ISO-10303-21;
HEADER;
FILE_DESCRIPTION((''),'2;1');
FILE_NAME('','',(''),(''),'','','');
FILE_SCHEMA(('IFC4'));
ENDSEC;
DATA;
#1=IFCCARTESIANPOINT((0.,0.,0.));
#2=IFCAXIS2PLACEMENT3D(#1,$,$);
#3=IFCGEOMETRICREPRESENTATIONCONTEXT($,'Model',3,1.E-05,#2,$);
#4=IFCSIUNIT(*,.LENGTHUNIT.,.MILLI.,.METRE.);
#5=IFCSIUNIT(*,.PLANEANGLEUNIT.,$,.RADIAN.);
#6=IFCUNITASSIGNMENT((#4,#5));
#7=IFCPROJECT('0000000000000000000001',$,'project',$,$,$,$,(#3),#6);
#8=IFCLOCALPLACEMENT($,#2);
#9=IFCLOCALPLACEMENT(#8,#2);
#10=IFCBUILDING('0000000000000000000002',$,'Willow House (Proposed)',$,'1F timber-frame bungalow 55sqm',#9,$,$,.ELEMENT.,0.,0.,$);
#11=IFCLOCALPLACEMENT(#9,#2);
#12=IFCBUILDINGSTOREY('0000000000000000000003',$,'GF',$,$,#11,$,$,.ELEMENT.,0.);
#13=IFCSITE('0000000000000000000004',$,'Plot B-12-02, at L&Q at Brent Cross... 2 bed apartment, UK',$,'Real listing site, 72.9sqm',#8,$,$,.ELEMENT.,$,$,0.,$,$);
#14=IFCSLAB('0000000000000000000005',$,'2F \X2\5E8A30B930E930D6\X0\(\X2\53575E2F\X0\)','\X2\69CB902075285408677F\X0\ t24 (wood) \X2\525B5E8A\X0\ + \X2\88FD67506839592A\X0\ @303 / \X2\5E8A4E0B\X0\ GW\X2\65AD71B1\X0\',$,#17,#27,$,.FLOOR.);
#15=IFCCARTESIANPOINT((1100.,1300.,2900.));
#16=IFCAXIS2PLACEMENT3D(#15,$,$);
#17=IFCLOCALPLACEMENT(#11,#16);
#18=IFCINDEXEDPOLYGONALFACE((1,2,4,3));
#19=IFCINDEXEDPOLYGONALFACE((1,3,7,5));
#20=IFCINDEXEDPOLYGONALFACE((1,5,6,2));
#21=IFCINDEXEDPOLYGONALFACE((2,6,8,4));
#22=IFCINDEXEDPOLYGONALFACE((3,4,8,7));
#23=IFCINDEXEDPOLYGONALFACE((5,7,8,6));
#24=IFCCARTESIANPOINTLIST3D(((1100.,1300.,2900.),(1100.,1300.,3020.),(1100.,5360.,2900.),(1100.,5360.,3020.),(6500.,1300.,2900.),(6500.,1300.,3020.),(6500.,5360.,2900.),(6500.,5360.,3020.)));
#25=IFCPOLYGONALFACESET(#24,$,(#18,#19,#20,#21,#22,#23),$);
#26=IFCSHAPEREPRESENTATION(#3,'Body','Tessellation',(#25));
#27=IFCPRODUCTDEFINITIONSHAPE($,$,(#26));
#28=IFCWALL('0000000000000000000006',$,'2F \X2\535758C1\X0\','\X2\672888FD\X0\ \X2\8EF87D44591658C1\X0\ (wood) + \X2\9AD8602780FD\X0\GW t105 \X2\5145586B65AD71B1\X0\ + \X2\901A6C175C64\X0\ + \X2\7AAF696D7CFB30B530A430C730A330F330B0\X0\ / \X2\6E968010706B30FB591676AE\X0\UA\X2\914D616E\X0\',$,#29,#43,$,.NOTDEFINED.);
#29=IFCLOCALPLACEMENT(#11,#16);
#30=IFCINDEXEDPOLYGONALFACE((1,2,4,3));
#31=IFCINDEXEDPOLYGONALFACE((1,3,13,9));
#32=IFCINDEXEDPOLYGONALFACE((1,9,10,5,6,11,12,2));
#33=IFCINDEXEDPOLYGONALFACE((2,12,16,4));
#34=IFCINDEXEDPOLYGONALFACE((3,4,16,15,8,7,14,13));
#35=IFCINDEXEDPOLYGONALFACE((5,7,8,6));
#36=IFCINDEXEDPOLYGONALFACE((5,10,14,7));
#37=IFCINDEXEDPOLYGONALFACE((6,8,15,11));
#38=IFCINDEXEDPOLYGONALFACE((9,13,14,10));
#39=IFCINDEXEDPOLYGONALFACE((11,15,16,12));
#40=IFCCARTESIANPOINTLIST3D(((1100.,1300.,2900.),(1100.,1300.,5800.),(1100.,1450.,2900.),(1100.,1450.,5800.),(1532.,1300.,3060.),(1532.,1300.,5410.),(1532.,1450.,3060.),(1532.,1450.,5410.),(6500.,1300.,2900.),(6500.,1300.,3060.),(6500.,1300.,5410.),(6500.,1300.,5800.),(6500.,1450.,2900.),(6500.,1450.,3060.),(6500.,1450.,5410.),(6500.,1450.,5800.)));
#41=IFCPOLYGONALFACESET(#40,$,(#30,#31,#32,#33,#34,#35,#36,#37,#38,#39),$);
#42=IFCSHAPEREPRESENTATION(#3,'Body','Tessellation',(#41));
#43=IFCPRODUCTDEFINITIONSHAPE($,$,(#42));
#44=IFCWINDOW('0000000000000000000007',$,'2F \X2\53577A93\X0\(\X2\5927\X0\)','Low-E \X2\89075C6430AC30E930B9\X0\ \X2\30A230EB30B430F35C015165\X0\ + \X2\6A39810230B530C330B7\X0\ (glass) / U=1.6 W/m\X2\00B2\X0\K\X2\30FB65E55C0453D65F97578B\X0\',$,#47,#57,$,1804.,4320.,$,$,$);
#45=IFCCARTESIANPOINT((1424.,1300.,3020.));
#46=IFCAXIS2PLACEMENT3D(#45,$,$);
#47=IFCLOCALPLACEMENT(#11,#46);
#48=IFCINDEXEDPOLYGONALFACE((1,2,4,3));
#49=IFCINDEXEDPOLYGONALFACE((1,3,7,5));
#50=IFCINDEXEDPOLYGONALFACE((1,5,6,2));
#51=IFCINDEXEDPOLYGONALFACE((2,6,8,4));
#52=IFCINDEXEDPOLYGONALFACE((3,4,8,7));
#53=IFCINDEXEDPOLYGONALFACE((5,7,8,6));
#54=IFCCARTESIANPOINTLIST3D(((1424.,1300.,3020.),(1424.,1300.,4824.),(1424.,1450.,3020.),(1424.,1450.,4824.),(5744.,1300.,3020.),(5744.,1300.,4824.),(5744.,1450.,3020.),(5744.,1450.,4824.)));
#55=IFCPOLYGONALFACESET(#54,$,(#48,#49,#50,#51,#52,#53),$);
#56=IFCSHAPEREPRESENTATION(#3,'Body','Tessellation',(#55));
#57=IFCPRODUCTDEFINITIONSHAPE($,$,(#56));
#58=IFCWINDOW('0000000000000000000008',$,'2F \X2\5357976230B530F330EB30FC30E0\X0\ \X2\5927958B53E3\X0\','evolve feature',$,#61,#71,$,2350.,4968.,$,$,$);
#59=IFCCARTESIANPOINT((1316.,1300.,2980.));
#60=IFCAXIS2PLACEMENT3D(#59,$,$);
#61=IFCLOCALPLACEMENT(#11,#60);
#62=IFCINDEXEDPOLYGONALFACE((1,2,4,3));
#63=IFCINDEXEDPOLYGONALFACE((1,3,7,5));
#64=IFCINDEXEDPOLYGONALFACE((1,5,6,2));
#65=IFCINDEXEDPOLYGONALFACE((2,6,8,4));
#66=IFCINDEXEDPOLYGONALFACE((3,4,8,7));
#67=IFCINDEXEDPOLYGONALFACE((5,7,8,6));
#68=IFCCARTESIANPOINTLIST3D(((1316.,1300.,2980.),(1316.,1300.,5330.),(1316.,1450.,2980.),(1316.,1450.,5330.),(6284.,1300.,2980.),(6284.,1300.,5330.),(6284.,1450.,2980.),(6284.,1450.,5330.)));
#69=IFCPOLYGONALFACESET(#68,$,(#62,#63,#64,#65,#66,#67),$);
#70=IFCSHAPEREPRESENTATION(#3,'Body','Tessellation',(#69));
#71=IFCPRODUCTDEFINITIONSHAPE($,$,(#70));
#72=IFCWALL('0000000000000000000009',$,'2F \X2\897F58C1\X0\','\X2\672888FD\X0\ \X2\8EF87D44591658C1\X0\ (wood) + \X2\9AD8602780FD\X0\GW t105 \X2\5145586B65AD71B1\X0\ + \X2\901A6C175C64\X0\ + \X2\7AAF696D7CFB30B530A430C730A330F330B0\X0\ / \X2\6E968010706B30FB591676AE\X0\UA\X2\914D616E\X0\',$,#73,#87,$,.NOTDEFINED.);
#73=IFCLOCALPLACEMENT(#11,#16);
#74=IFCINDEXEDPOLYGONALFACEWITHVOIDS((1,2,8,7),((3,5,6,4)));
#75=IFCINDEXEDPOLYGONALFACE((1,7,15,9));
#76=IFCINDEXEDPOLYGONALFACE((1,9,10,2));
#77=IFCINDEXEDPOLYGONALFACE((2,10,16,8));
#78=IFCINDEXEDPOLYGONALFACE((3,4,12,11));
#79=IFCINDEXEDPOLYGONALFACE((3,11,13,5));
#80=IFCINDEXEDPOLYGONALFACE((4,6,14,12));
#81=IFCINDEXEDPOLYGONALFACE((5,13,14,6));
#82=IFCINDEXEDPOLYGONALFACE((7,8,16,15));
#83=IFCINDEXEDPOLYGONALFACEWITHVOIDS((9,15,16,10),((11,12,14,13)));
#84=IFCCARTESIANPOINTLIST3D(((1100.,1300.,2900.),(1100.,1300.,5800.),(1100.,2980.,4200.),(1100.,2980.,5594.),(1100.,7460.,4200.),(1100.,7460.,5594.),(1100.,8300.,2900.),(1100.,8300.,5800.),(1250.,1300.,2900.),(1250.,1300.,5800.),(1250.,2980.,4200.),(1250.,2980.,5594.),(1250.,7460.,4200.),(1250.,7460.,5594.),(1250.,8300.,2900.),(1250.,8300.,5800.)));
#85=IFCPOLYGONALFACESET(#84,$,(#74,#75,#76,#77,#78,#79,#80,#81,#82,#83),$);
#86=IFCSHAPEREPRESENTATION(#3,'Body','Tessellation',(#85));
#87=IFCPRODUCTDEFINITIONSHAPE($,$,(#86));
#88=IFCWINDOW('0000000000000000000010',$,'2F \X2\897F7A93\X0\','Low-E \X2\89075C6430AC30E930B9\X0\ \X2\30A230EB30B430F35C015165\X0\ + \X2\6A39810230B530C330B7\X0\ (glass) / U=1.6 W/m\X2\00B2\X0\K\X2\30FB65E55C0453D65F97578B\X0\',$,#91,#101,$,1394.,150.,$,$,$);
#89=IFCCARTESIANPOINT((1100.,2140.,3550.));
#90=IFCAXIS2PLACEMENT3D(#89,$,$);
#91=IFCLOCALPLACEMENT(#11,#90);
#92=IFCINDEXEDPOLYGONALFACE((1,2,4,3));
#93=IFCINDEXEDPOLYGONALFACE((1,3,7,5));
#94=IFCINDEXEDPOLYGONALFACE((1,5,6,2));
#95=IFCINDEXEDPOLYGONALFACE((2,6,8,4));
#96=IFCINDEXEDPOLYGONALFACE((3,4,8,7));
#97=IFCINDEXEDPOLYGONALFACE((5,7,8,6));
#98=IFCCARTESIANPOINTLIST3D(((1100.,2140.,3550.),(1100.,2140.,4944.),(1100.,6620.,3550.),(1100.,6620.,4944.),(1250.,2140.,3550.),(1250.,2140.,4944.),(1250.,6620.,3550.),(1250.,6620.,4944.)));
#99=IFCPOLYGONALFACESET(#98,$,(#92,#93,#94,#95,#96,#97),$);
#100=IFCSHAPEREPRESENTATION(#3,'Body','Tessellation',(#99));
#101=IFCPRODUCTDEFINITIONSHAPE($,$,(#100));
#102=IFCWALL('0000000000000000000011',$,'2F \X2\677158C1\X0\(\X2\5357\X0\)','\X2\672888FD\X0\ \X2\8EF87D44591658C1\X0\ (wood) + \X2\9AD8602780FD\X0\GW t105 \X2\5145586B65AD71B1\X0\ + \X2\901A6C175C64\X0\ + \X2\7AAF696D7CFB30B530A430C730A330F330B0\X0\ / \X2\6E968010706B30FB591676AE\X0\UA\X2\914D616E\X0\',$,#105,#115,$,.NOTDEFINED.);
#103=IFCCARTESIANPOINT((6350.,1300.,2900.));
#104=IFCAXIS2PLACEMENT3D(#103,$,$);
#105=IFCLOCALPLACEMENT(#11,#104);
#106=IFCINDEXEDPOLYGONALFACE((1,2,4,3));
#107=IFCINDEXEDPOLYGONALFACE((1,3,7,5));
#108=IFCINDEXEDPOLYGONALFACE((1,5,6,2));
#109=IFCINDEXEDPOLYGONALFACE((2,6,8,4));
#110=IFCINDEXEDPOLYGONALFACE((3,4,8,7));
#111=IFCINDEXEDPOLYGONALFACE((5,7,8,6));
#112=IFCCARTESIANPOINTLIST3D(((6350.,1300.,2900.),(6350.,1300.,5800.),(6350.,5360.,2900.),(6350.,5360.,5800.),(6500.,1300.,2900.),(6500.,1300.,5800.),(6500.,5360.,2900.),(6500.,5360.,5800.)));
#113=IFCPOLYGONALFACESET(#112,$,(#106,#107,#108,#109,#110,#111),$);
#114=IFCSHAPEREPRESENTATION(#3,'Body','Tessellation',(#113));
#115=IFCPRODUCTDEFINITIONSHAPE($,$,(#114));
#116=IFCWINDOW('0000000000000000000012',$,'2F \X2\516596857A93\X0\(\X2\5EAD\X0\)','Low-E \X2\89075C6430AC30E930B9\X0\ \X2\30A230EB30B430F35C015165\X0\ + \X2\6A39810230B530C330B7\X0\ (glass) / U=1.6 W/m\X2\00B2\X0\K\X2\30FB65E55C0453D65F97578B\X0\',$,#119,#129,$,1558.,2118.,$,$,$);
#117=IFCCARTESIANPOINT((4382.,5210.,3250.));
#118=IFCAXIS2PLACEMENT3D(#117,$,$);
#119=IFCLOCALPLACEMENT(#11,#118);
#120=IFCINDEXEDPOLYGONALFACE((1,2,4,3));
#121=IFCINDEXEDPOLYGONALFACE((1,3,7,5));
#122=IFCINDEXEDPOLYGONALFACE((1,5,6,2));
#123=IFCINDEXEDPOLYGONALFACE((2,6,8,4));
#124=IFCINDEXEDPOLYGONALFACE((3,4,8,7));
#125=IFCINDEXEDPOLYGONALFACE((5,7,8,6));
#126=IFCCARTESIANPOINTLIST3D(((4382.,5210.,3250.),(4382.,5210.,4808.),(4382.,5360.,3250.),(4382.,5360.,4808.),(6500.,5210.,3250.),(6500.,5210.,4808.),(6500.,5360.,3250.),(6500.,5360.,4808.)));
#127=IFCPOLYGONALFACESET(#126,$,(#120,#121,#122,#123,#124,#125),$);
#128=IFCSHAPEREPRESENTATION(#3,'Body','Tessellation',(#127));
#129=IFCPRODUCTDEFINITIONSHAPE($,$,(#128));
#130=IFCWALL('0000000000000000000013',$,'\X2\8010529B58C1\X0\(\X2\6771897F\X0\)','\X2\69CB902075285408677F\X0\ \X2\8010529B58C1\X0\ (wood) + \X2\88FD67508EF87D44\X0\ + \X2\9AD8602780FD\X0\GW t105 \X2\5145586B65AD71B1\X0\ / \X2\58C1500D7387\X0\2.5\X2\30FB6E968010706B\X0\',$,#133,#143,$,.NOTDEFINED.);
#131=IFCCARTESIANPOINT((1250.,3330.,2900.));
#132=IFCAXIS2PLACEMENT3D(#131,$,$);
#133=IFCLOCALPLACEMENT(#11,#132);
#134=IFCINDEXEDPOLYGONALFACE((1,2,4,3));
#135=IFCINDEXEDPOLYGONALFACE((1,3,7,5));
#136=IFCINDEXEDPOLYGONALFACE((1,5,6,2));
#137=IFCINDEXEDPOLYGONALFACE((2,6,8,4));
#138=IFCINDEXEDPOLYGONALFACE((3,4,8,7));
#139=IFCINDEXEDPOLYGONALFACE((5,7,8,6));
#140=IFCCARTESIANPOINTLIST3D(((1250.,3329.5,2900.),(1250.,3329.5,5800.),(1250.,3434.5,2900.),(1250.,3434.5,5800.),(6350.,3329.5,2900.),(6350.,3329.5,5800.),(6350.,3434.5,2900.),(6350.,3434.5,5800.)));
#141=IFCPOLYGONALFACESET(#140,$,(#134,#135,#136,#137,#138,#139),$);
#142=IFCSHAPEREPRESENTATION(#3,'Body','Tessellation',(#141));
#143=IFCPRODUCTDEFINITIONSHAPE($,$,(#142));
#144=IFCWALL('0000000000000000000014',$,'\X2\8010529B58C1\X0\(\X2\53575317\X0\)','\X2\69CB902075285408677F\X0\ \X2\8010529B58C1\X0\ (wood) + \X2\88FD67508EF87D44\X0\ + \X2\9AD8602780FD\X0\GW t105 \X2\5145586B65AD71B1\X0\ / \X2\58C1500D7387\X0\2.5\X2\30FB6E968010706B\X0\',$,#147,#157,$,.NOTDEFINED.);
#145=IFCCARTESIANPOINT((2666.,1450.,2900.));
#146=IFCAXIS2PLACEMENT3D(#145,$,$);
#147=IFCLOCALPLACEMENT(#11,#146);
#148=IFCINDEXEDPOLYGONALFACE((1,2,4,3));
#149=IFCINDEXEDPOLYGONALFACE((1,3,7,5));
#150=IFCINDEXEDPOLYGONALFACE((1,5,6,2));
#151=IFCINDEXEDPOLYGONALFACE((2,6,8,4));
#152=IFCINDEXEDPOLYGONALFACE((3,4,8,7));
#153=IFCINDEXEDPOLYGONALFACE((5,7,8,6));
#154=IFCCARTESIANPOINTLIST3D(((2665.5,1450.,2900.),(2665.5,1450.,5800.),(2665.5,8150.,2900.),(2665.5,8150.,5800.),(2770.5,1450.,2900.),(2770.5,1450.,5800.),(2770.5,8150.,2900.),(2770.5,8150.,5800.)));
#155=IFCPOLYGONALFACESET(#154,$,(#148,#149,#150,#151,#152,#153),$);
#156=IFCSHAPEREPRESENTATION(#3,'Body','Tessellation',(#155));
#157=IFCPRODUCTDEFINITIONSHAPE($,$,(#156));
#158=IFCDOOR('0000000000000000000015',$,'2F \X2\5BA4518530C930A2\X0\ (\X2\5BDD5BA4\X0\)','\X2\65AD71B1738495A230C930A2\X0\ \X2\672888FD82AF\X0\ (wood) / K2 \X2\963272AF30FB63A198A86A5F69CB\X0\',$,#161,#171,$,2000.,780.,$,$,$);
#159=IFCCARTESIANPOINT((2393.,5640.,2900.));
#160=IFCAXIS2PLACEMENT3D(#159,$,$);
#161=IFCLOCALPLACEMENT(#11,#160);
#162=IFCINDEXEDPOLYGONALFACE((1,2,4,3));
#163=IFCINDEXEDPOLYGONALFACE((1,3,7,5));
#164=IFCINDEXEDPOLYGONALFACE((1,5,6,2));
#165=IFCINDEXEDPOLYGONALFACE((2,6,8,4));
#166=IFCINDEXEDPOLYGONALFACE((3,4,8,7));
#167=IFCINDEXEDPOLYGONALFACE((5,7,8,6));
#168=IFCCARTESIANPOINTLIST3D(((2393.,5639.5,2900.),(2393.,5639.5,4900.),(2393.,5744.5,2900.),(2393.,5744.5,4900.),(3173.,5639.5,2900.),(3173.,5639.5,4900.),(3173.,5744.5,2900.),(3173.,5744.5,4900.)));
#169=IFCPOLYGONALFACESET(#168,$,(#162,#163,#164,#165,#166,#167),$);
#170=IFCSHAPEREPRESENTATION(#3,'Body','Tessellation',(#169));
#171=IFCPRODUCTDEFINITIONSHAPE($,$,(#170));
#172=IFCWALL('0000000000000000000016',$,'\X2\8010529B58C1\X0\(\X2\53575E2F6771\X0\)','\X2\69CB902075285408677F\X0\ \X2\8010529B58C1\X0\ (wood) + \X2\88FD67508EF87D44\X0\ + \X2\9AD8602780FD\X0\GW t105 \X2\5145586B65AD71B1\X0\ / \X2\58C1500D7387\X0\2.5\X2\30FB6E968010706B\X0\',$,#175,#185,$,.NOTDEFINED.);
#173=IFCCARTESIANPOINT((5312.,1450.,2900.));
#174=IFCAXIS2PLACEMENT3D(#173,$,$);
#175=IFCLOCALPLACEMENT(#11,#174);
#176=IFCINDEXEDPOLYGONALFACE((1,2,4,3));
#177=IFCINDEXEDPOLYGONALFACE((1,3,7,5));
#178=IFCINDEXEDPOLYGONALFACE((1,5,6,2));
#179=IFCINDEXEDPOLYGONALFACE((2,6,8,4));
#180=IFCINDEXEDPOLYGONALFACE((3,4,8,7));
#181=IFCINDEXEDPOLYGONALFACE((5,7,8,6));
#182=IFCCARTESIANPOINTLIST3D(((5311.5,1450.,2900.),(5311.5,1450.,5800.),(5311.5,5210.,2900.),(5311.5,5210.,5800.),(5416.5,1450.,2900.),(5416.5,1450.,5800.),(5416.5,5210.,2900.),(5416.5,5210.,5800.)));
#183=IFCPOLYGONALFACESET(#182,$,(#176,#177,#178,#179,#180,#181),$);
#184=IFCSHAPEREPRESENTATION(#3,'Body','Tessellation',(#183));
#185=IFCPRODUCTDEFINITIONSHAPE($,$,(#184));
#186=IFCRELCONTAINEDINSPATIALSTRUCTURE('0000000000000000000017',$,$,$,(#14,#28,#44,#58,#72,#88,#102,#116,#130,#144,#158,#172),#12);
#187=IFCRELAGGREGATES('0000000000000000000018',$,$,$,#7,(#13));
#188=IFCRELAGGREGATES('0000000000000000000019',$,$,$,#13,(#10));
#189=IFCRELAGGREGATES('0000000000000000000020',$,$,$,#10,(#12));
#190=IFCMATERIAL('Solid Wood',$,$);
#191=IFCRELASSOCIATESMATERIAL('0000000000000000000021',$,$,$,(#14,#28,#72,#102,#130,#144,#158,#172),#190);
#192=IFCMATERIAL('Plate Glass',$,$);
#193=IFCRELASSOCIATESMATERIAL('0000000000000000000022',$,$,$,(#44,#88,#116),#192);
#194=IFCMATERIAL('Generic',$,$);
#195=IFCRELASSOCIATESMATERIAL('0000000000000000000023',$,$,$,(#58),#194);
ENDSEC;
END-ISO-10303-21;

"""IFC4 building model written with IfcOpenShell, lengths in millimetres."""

from ifc_helpers import new_model, si_unit, frame, frame_2d, origin, place, context, project, spatial, rectangle, extrude, material, element, fill, save


model = new_model("IFC4")

# Units and contexts
model_context = context("Model", 3, precision=1e-05, world=origin())
ifc_project = project(units=[si_unit("LENGTHUNIT", "METRE", prefix="MILLI"), si_unit("PLANEANGLEUNIT", "RADIAN")], contexts=[model_context])

# Site, building, storey
site_placement = place(None, origin())
site = spatial("IfcSite", under=ifc_project, at=site_placement, Name="Plot B-12-02, at L&Q at Brent Cross... 2 bed apartment, UK", ObjectType="Real listing site, 72.9sqm", CompositionType="ELEMENT", RefElevation=0.0)
building_placement = place(site_placement, origin())
building = spatial("IfcBuilding", under=site, at=building_placement, Name="Willow House (Proposed)", ObjectType="1F timber-frame bungalow 55sqm", CompositionType="ELEMENT", ElevationOfRefHeight=0.0, ElevationOfTerrain=0.0)
storey_placement = place(building_placement, origin())
storey = spatial("IfcBuildingStorey", under=building, at=storey_placement, Name="GF", CompositionType="ELEMENT", Elevation=0.0)

# Slab
ifc_material_1 = material(Name="Solid Wood")
slab_placement = place(storey_placement, frame((1100.0, 1300.0, 2900.0)))
element("IfcSlab", 1, at=slab_placement, inside=storey, material=ifc_material_1, Name="2F 床スラブ(南帯)", Description="構造用合板 t24 (wood) 剛床 + 製材根太 @303 / 床下 GW断熱", PredefinedType="FLOOR", context=model_context, shape_type="SweptSolid", body=[
    extrude(rectangle(XDim=5400.0, YDim=4060.0, at=frame_2d((2700.0, 2030.0))), frame((1100.0, 1300.0, 2900.0)), (0.0, 0.0, 1.0), 120.0),
])

# Wall, openings, windows
wall_1_placement = place(storey_placement, frame((1100.0, 1300.0, 2900.0)))
wall_1 = element("IfcWall", 2, at=wall_1_placement, inside=storey, material=ifc_material_1, Name="2F 南壁", Description="木製 軸組外壁 (wood) + 高性能GW t105 充填断熱 + 通気層 + 窯業系サイディング / 準耐火・外皮UA配慮", PredefinedType="NOTDEFINED", context=model_context, shape_type="SweptSolid", body=[
    extrude(rectangle(XDim=5400.0, YDim=150.0, at=frame_2d((2700.0, 75.0))), frame((1100.0, 1300.0, 2900.0)), (0.0, 0.0, 1.0), 2900.0),
])
opening_1_placement = place(storey_placement, frame((1424.0, 1300.0, 3020.0)))
opening_1 = element("IfcOpeningElement", 3, at=opening_1_placement, cuts=wall_1, PredefinedType="NOTDEFINED", context=model_context, shape_type="SweptSolid", body=[
    extrude(rectangle(XDim=4320.0, YDim=150.0, at=frame_2d((2160.0, 75.0))), frame((1424.0, 1300.0, 3020.0)), (0.0, 0.0, 1.0), 1804.0),
])
opening_2_placement = place(storey_placement, frame((1316.0, 1300.0, 2980.0)))
opening_2 = element("IfcOpeningElement", 4, at=opening_2_placement, cuts=wall_1, PredefinedType="NOTDEFINED", context=model_context, shape_type="SweptSolid", body=[
    extrude(rectangle(XDim=4968.0, YDim=150.0, at=frame_2d((2484.0, 75.0))), frame((1316.0, 1300.0, 2980.0)), (0.0, 0.0, 1.0), 2350.0),
])
ifc_material_2 = material(Name="Plate Glass")
window_1_placement = place(storey_placement, frame((1424.0, 1300.0, 3020.0)))
window_1 = element("IfcWindow", 5, at=window_1_placement, inside=storey, material=ifc_material_2, Name="2F 南窓(大)", Description="Low-E 複層ガラス アルゴン封入 + 樹脂サッシ (glass) / U=1.6 W/m²K・日射取得型", OverallHeight=1804.0, OverallWidth=4320.0, context=model_context, shape_type="SweptSolid", body=[
    extrude(rectangle(XDim=4320.0, YDim=150.0, at=frame_2d((2160.0, 75.0))), frame((1424.0, 1300.0, 3020.0)), (0.0, 0.0, 1.0), 1804.0),
])
fill(opening_1, window_1)
ifc_material_3 = material(Name="Generic")
window_2_placement = place(storey_placement, frame((1316.0, 1300.0, 2980.0)))
window_2 = element("IfcWindow", 6, at=window_2_placement, inside=storey, material=ifc_material_3, Name="2F 南面サンルーム 大開口", Description="evolve feature", OverallHeight=2350.0, OverallWidth=4968.0, context=model_context, shape_type="SweptSolid", body=[
    extrude(rectangle(XDim=4968.0, YDim=150.0, at=frame_2d((2484.0, 75.0))), frame((1316.0, 1300.0, 2980.0)), (0.0, 0.0, 1.0), 2350.0),
])
fill(opening_2, window_2)

# Walls, openings, windows
wall_2_placement = place(storey_placement, frame((1100.0, 1300.0, 2900.0)))
wall_2 = element("IfcWall", 7, at=wall_2_placement, inside=storey, material=ifc_material_1, Name="2F 西壁", Description="木製 軸組外壁 (wood) + 高性能GW t105 充填断熱 + 通気層 + 窯業系サイディング / 準耐火・外皮UA配慮", PredefinedType="NOTDEFINED", context=model_context, shape_type="SweptSolid", body=[
    extrude(rectangle(XDim=150.0, YDim=7000.0, at=frame_2d((75.0, 3500.0))), frame((1100.0, 1300.0, 2900.0)), (0.0, 0.0, 1.0), 2900.0),
])
opening_3_placement = place(storey_placement, frame((1100.0, 2140.0, 3550.0)))
opening_3 = element("IfcOpeningElement", 8, at=opening_3_placement, cuts=wall_2, PredefinedType="NOTDEFINED", context=model_context, shape_type="SweptSolid", body=[
    extrude(rectangle(XDim=150.0, YDim=4480.0, at=frame_2d((75.0, 2240.0))), frame((1100.0, 2140.0, 3550.0)), (0.0, 0.0, 1.0), 1394.0),
])
window_3_placement = place(storey_placement, frame((1100.0, 2140.0, 3550.0)))
window_3 = element("IfcWindow", 9, at=window_3_placement, inside=storey, material=ifc_material_2, Name="2F 西窓", Description="Low-E 複層ガラス アルゴン封入 + 樹脂サッシ (glass) / U=1.6 W/m²K・日射取得型", OverallHeight=1394.0, OverallWidth=150.0, context=model_context, shape_type="SweptSolid", body=[
    extrude(rectangle(XDim=150.0, YDim=4480.0, at=frame_2d((75.0, 2240.0))), frame((1100.0, 2140.0, 3550.0)), (0.0, 0.0, 1.0), 1394.0),
])
fill(opening_3, window_3)
wall_3_placement = place(storey_placement, frame((6350.0, 1300.0, 2900.0)))
wall_3 = element("IfcWall", 10, at=wall_3_placement, inside=storey, material=ifc_material_1, Name="2F 東壁(南)", Description="木製 軸組外壁 (wood) + 高性能GW t105 充填断熱 + 通気層 + 窯業系サイディング / 準耐火・外皮UA配慮", PredefinedType="NOTDEFINED", context=model_context, shape_type="SweptSolid", body=[
    extrude(rectangle(XDim=150.0, YDim=4060.0, at=frame_2d((75.0, 2030.0))), frame((6350.0, 1300.0, 2900.0)), (0.0, 0.0, 1.0), 2900.0),
])
opening_4_placement = place(storey_placement, frame((4382.0, 5210.0, 3250.0)))
opening_4 = element("IfcOpeningElement", 11, at=opening_4_placement, cuts=wall_3, PredefinedType="NOTDEFINED", context=model_context, shape_type="SweptSolid", body=[
    extrude(rectangle(XDim=2118.0, YDim=150.0, at=frame_2d((1059.0, 75.0))), frame((4382.0, 5210.0, 3250.0)), (0.0, 0.0, 1.0), 1558.0),
])
window_4_placement = place(storey_placement, frame((4382.0, 5210.0, 3250.0)))
window_4 = element("IfcWindow", 12, at=window_4_placement, inside=storey, material=ifc_material_2, Name="2F 入隅窓(庭)", Description="Low-E 複層ガラス アルゴン封入 + 樹脂サッシ (glass) / U=1.6 W/m²K・日射取得型", OverallHeight=1558.0, OverallWidth=2118.0, context=model_context, shape_type="SweptSolid", body=[
    extrude(rectangle(XDim=2118.0, YDim=150.0, at=frame_2d((1059.0, 75.0))), frame((4382.0, 5210.0, 3250.0)), (0.0, 0.0, 1.0), 1558.0),
])
fill(opening_4, window_4)

# Wall
wall_4_placement = place(storey_placement, frame((1250.0, 3330.0, 2900.0)))
element("IfcWall", 13, at=wall_4_placement, inside=storey, material=ifc_material_1, Name="耐力壁(東西)", Description="構造用合板 耐力壁 (wood) + 製材軸組 + 高性能GW t105 充填断熱 / 壁倍率2.5・準耐火", PredefinedType="NOTDEFINED", context=model_context, shape_type="SweptSolid", body=[
    extrude(rectangle(XDim=5100.0, YDim=105.0, at=frame_2d((2550.0, 52.0))), frame((1250.0, 3330.0, 2900.0)), (0.0, 0.0, 1.0), 2900.0),
])

# Wall, opening, door
wall_5_placement = place(storey_placement, frame((2666.0, 1450.0, 2900.0)))
wall_5 = element("IfcWall", 14, at=wall_5_placement, inside=storey, material=ifc_material_1, Name="耐力壁(南北)", Description="構造用合板 耐力壁 (wood) + 製材軸組 + 高性能GW t105 充填断熱 / 壁倍率2.5・準耐火", PredefinedType="NOTDEFINED", context=model_context, shape_type="SweptSolid", body=[
    extrude(rectangle(XDim=105.0, YDim=6700.0, at=frame_2d((52.0, 3350.0))), frame((2666.0, 1450.0, 2900.0)), (0.0, 0.0, 1.0), 2900.0),
])
opening_5_placement = place(storey_placement, frame((2393.0, 5640.0, 2900.0)))
opening_5 = element("IfcOpeningElement", 15, at=opening_5_placement, cuts=wall_5, PredefinedType="NOTDEFINED", context=model_context, shape_type="SweptSolid", body=[
    extrude(rectangle(XDim=780.0, YDim=105.0, at=frame_2d((390.0, 52.0))), frame((2393.0, 5640.0, 2900.0)), (0.0, 0.0, 1.0), 2000.0),
])
door_placement = place(storey_placement, frame((2393.0, 5640.0, 2900.0)))
door = element("IfcDoor", 16, at=door_placement, inside=storey, material=ifc_material_1, Name="2F 室内ドア (寝室)", Description="断熱玄関ドア 木製芯 (wood) / K2 防犯・採風機構", OverallHeight=2000.0, OverallWidth=780.0, context=model_context, shape_type="SweptSolid", body=[
    extrude(rectangle(XDim=780.0, YDim=105.0, at=frame_2d((390.0, 52.0))), frame((2393.0, 5640.0, 2900.0)), (0.0, 0.0, 1.0), 2000.0),
])
fill(opening_5, door)

# Wall
wall_6_placement = place(storey_placement, frame((5312.0, 1450.0, 2900.0)))
element("IfcWall", 17, at=wall_6_placement, inside=storey, material=ifc_material_1, Name="耐力壁(南帯東)", Description="構造用合板 耐力壁 (wood) + 製材軸組 + 高性能GW t105 充填断熱 / 壁倍率2.5・準耐火", PredefinedType="NOTDEFINED", context=model_context, shape_type="SweptSolid", body=[
    extrude(rectangle(XDim=105.0, YDim=3760.0, at=frame_2d((52.0, 1880.0))), frame((5312.0, 1450.0, 2900.0)), (0.0, 0.0, 1.0), 2900.0),
])

save(model, "model.ifc")
